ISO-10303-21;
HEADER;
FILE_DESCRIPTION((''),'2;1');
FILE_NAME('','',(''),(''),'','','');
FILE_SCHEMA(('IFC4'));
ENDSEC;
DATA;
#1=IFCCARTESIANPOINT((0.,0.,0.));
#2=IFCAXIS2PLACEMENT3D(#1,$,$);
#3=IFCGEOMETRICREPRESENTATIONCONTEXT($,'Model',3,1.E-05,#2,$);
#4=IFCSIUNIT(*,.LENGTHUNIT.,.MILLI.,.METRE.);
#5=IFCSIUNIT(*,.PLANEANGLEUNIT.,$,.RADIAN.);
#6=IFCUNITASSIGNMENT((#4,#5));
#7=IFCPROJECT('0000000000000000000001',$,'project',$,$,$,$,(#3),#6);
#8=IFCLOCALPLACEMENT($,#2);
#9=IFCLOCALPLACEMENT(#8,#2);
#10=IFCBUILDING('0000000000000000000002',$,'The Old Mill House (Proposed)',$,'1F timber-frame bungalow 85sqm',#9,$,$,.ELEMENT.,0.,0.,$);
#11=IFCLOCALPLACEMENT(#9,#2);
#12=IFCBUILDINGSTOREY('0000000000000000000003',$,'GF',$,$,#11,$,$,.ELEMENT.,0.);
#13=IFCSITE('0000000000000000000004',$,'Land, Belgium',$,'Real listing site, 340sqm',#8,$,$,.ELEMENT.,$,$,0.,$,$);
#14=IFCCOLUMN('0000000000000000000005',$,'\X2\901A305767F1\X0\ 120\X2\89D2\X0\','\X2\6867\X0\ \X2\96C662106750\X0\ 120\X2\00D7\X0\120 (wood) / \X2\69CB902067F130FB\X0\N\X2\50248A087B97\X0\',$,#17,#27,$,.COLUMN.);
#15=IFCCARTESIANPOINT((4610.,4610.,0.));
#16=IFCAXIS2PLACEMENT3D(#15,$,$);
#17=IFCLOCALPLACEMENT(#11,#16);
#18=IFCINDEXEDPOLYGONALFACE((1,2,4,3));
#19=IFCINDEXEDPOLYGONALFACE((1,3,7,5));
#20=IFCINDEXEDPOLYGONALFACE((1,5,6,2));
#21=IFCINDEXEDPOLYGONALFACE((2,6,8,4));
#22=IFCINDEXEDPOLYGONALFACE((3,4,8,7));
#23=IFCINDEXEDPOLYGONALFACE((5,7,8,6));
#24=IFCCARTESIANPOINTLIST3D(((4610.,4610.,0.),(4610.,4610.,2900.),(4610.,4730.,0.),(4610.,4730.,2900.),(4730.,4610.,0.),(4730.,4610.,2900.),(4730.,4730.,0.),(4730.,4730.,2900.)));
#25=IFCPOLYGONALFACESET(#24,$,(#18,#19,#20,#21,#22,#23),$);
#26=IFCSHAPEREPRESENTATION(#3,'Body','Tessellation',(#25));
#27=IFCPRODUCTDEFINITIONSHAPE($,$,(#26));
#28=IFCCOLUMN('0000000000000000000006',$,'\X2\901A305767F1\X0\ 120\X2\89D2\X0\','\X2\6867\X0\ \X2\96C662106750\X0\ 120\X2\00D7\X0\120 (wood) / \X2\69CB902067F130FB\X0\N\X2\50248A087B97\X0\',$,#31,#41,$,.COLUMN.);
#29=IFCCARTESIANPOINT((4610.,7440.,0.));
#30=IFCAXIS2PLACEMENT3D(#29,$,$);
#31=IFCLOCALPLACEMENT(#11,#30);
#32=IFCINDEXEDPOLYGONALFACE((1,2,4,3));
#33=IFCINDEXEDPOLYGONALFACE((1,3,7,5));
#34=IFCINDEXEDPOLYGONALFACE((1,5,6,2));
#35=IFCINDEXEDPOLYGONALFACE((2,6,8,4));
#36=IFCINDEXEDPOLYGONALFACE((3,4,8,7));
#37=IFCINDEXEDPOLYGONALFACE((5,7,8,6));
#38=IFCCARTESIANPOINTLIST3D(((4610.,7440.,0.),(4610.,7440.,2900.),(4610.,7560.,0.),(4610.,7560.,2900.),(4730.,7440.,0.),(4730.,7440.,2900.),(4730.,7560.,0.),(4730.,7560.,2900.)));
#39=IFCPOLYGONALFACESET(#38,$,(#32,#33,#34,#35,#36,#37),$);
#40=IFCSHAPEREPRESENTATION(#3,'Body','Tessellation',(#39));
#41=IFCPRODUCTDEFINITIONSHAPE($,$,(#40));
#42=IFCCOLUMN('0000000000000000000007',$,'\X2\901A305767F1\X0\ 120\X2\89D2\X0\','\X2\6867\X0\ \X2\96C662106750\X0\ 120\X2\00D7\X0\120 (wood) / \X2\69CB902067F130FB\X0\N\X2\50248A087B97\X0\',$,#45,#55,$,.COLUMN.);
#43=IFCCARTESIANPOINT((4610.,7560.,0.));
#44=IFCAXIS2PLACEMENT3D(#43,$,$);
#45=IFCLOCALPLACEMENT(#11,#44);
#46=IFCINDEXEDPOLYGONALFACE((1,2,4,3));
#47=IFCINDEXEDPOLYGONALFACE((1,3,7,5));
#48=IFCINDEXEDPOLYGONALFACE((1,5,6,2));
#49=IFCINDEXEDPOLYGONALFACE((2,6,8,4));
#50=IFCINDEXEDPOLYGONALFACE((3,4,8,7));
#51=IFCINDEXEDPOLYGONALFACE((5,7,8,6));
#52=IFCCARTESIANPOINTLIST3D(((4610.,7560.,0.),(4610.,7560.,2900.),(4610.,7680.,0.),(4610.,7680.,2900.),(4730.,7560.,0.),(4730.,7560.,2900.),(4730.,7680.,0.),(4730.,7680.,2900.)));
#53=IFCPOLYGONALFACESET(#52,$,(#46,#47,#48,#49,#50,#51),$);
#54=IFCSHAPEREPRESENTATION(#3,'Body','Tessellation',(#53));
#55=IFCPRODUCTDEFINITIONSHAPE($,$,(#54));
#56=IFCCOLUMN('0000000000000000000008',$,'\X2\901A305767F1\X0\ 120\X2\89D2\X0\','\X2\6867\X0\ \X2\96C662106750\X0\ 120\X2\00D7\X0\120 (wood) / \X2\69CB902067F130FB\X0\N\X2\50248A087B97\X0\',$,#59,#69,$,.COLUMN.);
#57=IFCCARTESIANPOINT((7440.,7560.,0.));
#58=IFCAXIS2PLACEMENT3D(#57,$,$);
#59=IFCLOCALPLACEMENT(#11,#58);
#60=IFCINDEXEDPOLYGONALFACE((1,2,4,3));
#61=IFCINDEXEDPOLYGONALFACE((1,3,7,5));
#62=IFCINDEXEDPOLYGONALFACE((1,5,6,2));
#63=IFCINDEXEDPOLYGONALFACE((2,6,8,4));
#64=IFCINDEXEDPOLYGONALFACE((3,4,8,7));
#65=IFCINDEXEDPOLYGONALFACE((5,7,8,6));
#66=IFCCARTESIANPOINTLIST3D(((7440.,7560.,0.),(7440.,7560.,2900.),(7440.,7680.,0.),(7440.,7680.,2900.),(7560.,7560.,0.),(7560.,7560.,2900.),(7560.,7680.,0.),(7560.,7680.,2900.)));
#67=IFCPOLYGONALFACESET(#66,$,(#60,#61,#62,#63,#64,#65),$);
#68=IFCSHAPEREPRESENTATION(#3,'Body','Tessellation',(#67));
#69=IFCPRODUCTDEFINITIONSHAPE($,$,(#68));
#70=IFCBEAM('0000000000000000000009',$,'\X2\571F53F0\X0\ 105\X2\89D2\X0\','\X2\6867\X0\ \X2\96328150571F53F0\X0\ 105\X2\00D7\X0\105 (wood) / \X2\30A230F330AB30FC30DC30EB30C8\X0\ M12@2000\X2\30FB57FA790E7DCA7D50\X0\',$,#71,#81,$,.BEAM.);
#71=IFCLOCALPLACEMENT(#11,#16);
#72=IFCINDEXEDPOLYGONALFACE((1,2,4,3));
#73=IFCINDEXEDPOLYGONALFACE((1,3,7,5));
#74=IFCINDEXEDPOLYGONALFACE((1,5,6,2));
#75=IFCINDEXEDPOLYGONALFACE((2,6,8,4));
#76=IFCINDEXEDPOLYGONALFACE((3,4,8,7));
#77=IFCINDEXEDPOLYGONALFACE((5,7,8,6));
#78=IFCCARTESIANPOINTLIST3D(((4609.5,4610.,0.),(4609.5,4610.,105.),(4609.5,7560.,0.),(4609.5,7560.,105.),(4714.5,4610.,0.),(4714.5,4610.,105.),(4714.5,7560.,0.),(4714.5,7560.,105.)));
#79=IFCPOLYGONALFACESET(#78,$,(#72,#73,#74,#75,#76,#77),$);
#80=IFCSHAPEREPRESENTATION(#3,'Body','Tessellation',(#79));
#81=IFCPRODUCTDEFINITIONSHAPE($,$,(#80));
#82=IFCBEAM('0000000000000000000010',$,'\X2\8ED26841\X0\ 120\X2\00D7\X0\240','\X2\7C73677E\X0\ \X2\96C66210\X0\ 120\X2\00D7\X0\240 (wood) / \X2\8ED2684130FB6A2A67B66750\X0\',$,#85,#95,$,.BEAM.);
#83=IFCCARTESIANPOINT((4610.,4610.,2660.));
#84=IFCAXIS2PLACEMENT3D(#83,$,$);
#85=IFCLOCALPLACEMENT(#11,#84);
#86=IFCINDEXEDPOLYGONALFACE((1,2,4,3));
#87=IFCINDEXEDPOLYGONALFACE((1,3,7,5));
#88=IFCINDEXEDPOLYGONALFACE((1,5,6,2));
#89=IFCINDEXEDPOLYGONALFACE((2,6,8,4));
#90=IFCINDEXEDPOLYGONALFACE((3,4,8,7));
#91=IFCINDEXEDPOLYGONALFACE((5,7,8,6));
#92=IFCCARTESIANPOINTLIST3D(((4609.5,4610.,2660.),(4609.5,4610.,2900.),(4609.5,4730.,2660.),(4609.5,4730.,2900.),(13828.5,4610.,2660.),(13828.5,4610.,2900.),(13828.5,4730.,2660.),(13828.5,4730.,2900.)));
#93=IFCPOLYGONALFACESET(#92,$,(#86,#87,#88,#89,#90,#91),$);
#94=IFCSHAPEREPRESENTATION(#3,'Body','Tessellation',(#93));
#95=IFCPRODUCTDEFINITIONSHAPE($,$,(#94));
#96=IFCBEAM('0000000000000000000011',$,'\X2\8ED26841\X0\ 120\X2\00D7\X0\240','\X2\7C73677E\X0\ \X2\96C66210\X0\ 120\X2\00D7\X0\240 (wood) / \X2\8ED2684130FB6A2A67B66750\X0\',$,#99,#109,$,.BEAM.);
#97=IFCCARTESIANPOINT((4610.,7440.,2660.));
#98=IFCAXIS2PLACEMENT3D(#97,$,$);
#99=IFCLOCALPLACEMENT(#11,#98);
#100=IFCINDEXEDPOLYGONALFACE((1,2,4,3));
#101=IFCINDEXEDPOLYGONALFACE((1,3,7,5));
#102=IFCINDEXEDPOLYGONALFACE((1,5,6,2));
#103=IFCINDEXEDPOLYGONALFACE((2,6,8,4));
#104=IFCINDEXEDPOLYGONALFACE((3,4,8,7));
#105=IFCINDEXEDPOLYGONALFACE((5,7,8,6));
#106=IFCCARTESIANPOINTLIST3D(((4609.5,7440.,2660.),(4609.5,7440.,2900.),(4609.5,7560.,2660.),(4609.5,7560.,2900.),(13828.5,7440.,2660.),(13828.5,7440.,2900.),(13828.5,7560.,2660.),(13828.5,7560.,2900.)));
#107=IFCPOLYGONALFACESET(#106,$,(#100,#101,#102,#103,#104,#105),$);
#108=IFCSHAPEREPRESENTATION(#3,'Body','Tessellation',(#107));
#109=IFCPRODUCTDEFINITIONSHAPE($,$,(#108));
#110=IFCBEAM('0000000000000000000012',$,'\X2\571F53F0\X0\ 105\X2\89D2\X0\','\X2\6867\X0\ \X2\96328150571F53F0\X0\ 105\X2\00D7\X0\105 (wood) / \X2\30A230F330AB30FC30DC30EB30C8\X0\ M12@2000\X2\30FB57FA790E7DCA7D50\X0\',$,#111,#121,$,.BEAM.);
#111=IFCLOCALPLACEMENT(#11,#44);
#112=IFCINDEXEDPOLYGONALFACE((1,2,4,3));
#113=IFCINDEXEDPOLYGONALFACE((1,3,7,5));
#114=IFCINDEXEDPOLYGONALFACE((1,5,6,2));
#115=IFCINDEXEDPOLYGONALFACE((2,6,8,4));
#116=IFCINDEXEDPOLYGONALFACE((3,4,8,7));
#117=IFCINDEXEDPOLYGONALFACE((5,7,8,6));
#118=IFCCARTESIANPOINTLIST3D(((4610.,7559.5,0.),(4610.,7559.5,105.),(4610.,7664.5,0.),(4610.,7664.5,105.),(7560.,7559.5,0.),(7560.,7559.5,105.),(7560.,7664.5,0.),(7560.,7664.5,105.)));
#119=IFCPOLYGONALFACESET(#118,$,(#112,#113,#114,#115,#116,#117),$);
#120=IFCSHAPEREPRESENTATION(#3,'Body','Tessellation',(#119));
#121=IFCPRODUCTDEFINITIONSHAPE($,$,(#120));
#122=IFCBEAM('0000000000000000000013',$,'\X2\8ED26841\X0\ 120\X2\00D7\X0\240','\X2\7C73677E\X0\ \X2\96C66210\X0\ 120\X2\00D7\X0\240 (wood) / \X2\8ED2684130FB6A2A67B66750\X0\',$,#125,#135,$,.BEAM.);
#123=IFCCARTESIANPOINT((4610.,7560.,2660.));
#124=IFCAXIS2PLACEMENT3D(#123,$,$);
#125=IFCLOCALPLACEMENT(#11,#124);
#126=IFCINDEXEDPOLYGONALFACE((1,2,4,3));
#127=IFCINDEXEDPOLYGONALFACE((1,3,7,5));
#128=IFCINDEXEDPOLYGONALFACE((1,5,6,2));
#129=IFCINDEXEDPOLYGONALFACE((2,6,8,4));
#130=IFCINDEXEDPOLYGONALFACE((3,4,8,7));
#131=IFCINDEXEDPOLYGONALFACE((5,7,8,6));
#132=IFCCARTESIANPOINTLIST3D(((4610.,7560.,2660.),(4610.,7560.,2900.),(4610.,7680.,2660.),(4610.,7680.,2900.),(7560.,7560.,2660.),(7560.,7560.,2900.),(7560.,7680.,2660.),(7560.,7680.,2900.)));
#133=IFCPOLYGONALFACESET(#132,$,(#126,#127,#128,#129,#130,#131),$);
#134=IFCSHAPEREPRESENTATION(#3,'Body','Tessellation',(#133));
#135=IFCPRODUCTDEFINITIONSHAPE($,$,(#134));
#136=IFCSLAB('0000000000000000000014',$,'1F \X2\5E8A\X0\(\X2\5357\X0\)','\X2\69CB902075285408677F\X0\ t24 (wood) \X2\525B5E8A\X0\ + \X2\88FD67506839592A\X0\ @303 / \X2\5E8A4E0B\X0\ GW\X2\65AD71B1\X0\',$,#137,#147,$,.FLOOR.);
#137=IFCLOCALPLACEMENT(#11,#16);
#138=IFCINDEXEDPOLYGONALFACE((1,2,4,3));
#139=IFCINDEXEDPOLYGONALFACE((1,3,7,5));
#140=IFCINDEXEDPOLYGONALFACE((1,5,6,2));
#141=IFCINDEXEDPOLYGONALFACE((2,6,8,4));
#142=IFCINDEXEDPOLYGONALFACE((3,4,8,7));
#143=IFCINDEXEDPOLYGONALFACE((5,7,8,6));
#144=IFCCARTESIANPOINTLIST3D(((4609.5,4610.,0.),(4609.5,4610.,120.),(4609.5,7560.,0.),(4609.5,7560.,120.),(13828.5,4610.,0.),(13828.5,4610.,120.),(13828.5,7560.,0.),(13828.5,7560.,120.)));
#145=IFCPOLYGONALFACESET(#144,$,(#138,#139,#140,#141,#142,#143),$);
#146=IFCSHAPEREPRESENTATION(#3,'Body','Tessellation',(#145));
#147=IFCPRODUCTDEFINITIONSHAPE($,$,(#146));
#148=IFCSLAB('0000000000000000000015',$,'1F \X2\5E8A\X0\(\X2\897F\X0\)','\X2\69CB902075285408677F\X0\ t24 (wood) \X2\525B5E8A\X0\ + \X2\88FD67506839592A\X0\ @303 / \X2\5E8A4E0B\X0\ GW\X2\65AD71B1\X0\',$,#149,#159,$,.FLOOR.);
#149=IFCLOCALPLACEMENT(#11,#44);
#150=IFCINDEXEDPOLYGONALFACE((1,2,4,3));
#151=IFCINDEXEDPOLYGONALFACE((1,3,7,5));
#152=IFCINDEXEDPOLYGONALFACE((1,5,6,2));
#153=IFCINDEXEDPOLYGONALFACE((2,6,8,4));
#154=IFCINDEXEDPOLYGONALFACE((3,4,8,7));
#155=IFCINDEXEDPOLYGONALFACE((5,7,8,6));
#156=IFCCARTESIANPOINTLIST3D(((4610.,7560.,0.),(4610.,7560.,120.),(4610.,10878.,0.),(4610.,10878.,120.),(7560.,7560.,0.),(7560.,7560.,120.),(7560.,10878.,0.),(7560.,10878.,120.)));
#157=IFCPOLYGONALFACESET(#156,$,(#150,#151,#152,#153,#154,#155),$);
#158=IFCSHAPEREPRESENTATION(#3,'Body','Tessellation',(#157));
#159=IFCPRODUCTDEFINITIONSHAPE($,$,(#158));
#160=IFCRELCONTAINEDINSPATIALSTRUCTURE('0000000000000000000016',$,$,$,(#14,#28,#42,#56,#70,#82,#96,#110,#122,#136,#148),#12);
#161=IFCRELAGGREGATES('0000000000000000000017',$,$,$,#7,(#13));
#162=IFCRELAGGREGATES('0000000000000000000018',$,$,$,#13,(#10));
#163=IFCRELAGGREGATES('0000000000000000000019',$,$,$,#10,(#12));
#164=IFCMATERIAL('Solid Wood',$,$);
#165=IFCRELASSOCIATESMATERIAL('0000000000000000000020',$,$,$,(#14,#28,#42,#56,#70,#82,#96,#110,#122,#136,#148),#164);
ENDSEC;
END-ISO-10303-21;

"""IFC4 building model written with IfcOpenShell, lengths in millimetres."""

from ifc_helpers import new_model, si_unit, frame, frame_2d, origin, place, context, project, spatial, rectangle, extrude, material, element, save


model = new_model("IFC4")

# Units and contexts
model_context = context("Model", 3, precision=1e-05, world=origin())
ifc_project = project(units=[si_unit("LENGTHUNIT", "METRE", prefix="MILLI"), si_unit("PLANEANGLEUNIT", "RADIAN")], contexts=[model_context])

# Site, building, storey
site_placement = place(None, origin())
site = spatial("IfcSite", under=ifc_project, at=site_placement, Name="Land, Belgium", ObjectType="Real listing site, 340sqm", CompositionType="ELEMENT", RefElevation=0.0)
building_placement = place(site_placement, origin())
building = spatial("IfcBuilding", under=site, at=building_placement, Name="The Old Mill House (Proposed)", ObjectType="1F timber-frame bungalow 85sqm", CompositionType="ELEMENT", ElevationOfRefHeight=0.0, ElevationOfTerrain=0.0)
storey_placement = place(building_placement, origin())
storey = spatial("IfcBuildingStorey", under=building, at=storey_placement, Name="GF", CompositionType="ELEMENT", Elevation=0.0)

# Columns
ifc_material_1 = material(Name="Solid Wood")
column_1_placement = place(storey_placement, frame((4610.0, 4610.0, 0.0)))
element("IfcColumn", 1, at=column_1_placement, inside=storey, material=ifc_material_1, Name="通し柱 120角", Description="桧 集成材 120×120 (wood) / 構造柱・N値計算", PredefinedType="COLUMN", context=model_context, shape_type="SweptSolid", body=[
    extrude(rectangle(XDim=120.0, YDim=120.0, at=frame_2d((60.0, 60.0))), frame((4610.0, 4610.0, 0.0)), (0.0, 0.0, 1.0), 2900.0),
])
column_2_placement = place(storey_placement, frame((4610.0, 7440.0, 0.0)))
element("IfcColumn", 2, at=column_2_placement, inside=storey, material=ifc_material_1, Name="通し柱 120角", Description="桧 集成材 120×120 (wood) / 構造柱・N値計算", PredefinedType="COLUMN", context=model_context, shape_type="SweptSolid", body=[
    extrude(rectangle(XDim=120.0, YDim=120.0, at=frame_2d((60.0, 60.0))), frame((4610.0, 7440.0, 0.0)), (0.0, 0.0, 1.0), 2900.0),
])
column_3_placement = place(storey_placement, frame((4610.0, 7560.0, 0.0)))
element("IfcColumn", 3, at=column_3_placement, inside=storey, material=ifc_material_1, Name="通し柱 120角", Description="桧 集成材 120×120 (wood) / 構造柱・N値計算", PredefinedType="COLUMN", context=model_context, shape_type="SweptSolid", body=[
    extrude(rectangle(XDim=120.0, YDim=120.0, at=frame_2d((60.0, 60.0))), frame((4610.0, 7560.0, 0.0)), (0.0, 0.0, 1.0), 2900.0),
])
column_4_placement = place(storey_placement, frame((7440.0, 7560.0, 0.0)))
element("IfcColumn", 4, at=column_4_placement, inside=storey, material=ifc_material_1, Name="通し柱 120角", Description="桧 集成材 120×120 (wood) / 構造柱・N値計算", PredefinedType="COLUMN", context=model_context, shape_type="SweptSolid", body=[
    extrude(rectangle(XDim=120.0, YDim=120.0, at=frame_2d((60.0, 60.0))), frame((7440.0, 7560.0, 0.0)), (0.0, 0.0, 1.0), 2900.0),
])

# Beams
beam_1_placement = place(storey_placement, frame((4610.0, 4610.0, 0.0)))
element("IfcBeam", 5, at=beam_1_placement, inside=storey, material=ifc_material_1, Name="土台 105角", Description="桧 防腐土台 105×105 (wood) / アンカーボルト M12@2000・基礎緊結", PredefinedType="BEAM", context=model_context, shape_type="SweptSolid", body=[
    extrude(rectangle(XDim=105.0, YDim=2950.0, at=frame_2d((52.0, 1475.0))), frame((4610.0, 4610.0, 0.0)), (0.0, 0.0, 1.0), 105.0),
])
beam_2_placement = place(storey_placement, frame((4610.0, 4610.0, 2660.0)))
element("IfcBeam", 6, at=beam_2_placement, inside=storey, material=ifc_material_1, Name="軒桁 120×240", Description="米松 集成 120×240 (wood) / 軒桁・横架材", PredefinedType="BEAM", context=model_context, shape_type="SweptSolid", body=[
    extrude(rectangle(XDim=9219.0, YDim=120.0, at=frame_2d((4609.0, 60.0))), frame((4610.0, 4610.0, 2660.0)), (0.0, 0.0, 1.0), 240.0),
])
beam_3_placement = place(storey_placement, frame((4610.0, 7440.0, 2660.0)))
element("IfcBeam", 7, at=beam_3_placement, inside=storey, material=ifc_material_1, Name="軒桁 120×240", Description="米松 集成 120×240 (wood) / 軒桁・横架材", PredefinedType="BEAM", context=model_context, shape_type="SweptSolid", body=[
    extrude(rectangle(XDim=9219.0, YDim=120.0, at=frame_2d((4609.0, 60.0))), frame((4610.0, 7440.0, 2660.0)), (0.0, 0.0, 1.0), 240.0),
])
beam_4_placement = place(storey_placement, frame((4610.0, 7560.0, 0.0)))
element("IfcBeam", 8, at=beam_4_placement, inside=storey, material=ifc_material_1, Name="土台 105角", Description="桧 防腐土台 105×105 (wood) / アンカーボルト M12@2000・基礎緊結", PredefinedType="BEAM", context=model_context, shape_type="SweptSolid", body=[
    extrude(rectangle(XDim=2950.0, YDim=105.0, at=frame_2d((1475.0, 52.0))), frame((4610.0, 7560.0, 0.0)), (0.0, 0.0, 1.0), 105.0),
])
beam_5_placement = place(storey_placement, frame((4610.0, 7560.0, 2660.0)))
element("IfcBeam", 9, at=beam_5_placement, inside=storey, material=ifc_material_1, Name="軒桁 120×240", Description="米松 集成 120×240 (wood) / 軒桁・横架材", PredefinedType="BEAM", context=model_context, shape_type="SweptSolid", body=[
    extrude(rectangle(XDim=2950.0, YDim=120.0, at=frame_2d((1475.0, 60.0))), frame((4610.0, 7560.0, 2660.0)), (0.0, 0.0, 1.0), 240.0),
])

# Slabs
slab_1_placement = place(storey_placement, frame((4610.0, 4610.0, 0.0)))
element("IfcSlab", 10, at=slab_1_placement, inside=storey, material=ifc_material_1, Name="1F 床(南)", Description="構造用合板 t24 (wood) 剛床 + 製材根太 @303 / 床下 GW断熱", PredefinedType="FLOOR", context=model_context, shape_type="SweptSolid", body=[
    extrude(rectangle(XDim=9219.0, YDim=2950.0, at=frame_2d((4609.0, 1475.0))), frame((4610.0, 4610.0, 0.0)), (0.0, 0.0, 1.0), 120.0),
])
slab_2_placement = place(storey_placement, frame((4610.0, 7560.0, 0.0)))
element("IfcSlab", 11, at=slab_2_placement, inside=storey, material=ifc_material_1, Name="1F 床(西)", Description="構造用合板 t24 (wood) 剛床 + 製材根太 @303 / 床下 GW断熱", PredefinedType="FLOOR", context=model_context, shape_type="SweptSolid", body=[
    extrude(rectangle(XDim=2950.0, YDim=3318.0, at=frame_2d((1475.0, 1659.0))), frame((4610.0, 7560.0, 0.0)), (0.0, 0.0, 1.0), 120.0),
])

save(model, "model.ifc")
